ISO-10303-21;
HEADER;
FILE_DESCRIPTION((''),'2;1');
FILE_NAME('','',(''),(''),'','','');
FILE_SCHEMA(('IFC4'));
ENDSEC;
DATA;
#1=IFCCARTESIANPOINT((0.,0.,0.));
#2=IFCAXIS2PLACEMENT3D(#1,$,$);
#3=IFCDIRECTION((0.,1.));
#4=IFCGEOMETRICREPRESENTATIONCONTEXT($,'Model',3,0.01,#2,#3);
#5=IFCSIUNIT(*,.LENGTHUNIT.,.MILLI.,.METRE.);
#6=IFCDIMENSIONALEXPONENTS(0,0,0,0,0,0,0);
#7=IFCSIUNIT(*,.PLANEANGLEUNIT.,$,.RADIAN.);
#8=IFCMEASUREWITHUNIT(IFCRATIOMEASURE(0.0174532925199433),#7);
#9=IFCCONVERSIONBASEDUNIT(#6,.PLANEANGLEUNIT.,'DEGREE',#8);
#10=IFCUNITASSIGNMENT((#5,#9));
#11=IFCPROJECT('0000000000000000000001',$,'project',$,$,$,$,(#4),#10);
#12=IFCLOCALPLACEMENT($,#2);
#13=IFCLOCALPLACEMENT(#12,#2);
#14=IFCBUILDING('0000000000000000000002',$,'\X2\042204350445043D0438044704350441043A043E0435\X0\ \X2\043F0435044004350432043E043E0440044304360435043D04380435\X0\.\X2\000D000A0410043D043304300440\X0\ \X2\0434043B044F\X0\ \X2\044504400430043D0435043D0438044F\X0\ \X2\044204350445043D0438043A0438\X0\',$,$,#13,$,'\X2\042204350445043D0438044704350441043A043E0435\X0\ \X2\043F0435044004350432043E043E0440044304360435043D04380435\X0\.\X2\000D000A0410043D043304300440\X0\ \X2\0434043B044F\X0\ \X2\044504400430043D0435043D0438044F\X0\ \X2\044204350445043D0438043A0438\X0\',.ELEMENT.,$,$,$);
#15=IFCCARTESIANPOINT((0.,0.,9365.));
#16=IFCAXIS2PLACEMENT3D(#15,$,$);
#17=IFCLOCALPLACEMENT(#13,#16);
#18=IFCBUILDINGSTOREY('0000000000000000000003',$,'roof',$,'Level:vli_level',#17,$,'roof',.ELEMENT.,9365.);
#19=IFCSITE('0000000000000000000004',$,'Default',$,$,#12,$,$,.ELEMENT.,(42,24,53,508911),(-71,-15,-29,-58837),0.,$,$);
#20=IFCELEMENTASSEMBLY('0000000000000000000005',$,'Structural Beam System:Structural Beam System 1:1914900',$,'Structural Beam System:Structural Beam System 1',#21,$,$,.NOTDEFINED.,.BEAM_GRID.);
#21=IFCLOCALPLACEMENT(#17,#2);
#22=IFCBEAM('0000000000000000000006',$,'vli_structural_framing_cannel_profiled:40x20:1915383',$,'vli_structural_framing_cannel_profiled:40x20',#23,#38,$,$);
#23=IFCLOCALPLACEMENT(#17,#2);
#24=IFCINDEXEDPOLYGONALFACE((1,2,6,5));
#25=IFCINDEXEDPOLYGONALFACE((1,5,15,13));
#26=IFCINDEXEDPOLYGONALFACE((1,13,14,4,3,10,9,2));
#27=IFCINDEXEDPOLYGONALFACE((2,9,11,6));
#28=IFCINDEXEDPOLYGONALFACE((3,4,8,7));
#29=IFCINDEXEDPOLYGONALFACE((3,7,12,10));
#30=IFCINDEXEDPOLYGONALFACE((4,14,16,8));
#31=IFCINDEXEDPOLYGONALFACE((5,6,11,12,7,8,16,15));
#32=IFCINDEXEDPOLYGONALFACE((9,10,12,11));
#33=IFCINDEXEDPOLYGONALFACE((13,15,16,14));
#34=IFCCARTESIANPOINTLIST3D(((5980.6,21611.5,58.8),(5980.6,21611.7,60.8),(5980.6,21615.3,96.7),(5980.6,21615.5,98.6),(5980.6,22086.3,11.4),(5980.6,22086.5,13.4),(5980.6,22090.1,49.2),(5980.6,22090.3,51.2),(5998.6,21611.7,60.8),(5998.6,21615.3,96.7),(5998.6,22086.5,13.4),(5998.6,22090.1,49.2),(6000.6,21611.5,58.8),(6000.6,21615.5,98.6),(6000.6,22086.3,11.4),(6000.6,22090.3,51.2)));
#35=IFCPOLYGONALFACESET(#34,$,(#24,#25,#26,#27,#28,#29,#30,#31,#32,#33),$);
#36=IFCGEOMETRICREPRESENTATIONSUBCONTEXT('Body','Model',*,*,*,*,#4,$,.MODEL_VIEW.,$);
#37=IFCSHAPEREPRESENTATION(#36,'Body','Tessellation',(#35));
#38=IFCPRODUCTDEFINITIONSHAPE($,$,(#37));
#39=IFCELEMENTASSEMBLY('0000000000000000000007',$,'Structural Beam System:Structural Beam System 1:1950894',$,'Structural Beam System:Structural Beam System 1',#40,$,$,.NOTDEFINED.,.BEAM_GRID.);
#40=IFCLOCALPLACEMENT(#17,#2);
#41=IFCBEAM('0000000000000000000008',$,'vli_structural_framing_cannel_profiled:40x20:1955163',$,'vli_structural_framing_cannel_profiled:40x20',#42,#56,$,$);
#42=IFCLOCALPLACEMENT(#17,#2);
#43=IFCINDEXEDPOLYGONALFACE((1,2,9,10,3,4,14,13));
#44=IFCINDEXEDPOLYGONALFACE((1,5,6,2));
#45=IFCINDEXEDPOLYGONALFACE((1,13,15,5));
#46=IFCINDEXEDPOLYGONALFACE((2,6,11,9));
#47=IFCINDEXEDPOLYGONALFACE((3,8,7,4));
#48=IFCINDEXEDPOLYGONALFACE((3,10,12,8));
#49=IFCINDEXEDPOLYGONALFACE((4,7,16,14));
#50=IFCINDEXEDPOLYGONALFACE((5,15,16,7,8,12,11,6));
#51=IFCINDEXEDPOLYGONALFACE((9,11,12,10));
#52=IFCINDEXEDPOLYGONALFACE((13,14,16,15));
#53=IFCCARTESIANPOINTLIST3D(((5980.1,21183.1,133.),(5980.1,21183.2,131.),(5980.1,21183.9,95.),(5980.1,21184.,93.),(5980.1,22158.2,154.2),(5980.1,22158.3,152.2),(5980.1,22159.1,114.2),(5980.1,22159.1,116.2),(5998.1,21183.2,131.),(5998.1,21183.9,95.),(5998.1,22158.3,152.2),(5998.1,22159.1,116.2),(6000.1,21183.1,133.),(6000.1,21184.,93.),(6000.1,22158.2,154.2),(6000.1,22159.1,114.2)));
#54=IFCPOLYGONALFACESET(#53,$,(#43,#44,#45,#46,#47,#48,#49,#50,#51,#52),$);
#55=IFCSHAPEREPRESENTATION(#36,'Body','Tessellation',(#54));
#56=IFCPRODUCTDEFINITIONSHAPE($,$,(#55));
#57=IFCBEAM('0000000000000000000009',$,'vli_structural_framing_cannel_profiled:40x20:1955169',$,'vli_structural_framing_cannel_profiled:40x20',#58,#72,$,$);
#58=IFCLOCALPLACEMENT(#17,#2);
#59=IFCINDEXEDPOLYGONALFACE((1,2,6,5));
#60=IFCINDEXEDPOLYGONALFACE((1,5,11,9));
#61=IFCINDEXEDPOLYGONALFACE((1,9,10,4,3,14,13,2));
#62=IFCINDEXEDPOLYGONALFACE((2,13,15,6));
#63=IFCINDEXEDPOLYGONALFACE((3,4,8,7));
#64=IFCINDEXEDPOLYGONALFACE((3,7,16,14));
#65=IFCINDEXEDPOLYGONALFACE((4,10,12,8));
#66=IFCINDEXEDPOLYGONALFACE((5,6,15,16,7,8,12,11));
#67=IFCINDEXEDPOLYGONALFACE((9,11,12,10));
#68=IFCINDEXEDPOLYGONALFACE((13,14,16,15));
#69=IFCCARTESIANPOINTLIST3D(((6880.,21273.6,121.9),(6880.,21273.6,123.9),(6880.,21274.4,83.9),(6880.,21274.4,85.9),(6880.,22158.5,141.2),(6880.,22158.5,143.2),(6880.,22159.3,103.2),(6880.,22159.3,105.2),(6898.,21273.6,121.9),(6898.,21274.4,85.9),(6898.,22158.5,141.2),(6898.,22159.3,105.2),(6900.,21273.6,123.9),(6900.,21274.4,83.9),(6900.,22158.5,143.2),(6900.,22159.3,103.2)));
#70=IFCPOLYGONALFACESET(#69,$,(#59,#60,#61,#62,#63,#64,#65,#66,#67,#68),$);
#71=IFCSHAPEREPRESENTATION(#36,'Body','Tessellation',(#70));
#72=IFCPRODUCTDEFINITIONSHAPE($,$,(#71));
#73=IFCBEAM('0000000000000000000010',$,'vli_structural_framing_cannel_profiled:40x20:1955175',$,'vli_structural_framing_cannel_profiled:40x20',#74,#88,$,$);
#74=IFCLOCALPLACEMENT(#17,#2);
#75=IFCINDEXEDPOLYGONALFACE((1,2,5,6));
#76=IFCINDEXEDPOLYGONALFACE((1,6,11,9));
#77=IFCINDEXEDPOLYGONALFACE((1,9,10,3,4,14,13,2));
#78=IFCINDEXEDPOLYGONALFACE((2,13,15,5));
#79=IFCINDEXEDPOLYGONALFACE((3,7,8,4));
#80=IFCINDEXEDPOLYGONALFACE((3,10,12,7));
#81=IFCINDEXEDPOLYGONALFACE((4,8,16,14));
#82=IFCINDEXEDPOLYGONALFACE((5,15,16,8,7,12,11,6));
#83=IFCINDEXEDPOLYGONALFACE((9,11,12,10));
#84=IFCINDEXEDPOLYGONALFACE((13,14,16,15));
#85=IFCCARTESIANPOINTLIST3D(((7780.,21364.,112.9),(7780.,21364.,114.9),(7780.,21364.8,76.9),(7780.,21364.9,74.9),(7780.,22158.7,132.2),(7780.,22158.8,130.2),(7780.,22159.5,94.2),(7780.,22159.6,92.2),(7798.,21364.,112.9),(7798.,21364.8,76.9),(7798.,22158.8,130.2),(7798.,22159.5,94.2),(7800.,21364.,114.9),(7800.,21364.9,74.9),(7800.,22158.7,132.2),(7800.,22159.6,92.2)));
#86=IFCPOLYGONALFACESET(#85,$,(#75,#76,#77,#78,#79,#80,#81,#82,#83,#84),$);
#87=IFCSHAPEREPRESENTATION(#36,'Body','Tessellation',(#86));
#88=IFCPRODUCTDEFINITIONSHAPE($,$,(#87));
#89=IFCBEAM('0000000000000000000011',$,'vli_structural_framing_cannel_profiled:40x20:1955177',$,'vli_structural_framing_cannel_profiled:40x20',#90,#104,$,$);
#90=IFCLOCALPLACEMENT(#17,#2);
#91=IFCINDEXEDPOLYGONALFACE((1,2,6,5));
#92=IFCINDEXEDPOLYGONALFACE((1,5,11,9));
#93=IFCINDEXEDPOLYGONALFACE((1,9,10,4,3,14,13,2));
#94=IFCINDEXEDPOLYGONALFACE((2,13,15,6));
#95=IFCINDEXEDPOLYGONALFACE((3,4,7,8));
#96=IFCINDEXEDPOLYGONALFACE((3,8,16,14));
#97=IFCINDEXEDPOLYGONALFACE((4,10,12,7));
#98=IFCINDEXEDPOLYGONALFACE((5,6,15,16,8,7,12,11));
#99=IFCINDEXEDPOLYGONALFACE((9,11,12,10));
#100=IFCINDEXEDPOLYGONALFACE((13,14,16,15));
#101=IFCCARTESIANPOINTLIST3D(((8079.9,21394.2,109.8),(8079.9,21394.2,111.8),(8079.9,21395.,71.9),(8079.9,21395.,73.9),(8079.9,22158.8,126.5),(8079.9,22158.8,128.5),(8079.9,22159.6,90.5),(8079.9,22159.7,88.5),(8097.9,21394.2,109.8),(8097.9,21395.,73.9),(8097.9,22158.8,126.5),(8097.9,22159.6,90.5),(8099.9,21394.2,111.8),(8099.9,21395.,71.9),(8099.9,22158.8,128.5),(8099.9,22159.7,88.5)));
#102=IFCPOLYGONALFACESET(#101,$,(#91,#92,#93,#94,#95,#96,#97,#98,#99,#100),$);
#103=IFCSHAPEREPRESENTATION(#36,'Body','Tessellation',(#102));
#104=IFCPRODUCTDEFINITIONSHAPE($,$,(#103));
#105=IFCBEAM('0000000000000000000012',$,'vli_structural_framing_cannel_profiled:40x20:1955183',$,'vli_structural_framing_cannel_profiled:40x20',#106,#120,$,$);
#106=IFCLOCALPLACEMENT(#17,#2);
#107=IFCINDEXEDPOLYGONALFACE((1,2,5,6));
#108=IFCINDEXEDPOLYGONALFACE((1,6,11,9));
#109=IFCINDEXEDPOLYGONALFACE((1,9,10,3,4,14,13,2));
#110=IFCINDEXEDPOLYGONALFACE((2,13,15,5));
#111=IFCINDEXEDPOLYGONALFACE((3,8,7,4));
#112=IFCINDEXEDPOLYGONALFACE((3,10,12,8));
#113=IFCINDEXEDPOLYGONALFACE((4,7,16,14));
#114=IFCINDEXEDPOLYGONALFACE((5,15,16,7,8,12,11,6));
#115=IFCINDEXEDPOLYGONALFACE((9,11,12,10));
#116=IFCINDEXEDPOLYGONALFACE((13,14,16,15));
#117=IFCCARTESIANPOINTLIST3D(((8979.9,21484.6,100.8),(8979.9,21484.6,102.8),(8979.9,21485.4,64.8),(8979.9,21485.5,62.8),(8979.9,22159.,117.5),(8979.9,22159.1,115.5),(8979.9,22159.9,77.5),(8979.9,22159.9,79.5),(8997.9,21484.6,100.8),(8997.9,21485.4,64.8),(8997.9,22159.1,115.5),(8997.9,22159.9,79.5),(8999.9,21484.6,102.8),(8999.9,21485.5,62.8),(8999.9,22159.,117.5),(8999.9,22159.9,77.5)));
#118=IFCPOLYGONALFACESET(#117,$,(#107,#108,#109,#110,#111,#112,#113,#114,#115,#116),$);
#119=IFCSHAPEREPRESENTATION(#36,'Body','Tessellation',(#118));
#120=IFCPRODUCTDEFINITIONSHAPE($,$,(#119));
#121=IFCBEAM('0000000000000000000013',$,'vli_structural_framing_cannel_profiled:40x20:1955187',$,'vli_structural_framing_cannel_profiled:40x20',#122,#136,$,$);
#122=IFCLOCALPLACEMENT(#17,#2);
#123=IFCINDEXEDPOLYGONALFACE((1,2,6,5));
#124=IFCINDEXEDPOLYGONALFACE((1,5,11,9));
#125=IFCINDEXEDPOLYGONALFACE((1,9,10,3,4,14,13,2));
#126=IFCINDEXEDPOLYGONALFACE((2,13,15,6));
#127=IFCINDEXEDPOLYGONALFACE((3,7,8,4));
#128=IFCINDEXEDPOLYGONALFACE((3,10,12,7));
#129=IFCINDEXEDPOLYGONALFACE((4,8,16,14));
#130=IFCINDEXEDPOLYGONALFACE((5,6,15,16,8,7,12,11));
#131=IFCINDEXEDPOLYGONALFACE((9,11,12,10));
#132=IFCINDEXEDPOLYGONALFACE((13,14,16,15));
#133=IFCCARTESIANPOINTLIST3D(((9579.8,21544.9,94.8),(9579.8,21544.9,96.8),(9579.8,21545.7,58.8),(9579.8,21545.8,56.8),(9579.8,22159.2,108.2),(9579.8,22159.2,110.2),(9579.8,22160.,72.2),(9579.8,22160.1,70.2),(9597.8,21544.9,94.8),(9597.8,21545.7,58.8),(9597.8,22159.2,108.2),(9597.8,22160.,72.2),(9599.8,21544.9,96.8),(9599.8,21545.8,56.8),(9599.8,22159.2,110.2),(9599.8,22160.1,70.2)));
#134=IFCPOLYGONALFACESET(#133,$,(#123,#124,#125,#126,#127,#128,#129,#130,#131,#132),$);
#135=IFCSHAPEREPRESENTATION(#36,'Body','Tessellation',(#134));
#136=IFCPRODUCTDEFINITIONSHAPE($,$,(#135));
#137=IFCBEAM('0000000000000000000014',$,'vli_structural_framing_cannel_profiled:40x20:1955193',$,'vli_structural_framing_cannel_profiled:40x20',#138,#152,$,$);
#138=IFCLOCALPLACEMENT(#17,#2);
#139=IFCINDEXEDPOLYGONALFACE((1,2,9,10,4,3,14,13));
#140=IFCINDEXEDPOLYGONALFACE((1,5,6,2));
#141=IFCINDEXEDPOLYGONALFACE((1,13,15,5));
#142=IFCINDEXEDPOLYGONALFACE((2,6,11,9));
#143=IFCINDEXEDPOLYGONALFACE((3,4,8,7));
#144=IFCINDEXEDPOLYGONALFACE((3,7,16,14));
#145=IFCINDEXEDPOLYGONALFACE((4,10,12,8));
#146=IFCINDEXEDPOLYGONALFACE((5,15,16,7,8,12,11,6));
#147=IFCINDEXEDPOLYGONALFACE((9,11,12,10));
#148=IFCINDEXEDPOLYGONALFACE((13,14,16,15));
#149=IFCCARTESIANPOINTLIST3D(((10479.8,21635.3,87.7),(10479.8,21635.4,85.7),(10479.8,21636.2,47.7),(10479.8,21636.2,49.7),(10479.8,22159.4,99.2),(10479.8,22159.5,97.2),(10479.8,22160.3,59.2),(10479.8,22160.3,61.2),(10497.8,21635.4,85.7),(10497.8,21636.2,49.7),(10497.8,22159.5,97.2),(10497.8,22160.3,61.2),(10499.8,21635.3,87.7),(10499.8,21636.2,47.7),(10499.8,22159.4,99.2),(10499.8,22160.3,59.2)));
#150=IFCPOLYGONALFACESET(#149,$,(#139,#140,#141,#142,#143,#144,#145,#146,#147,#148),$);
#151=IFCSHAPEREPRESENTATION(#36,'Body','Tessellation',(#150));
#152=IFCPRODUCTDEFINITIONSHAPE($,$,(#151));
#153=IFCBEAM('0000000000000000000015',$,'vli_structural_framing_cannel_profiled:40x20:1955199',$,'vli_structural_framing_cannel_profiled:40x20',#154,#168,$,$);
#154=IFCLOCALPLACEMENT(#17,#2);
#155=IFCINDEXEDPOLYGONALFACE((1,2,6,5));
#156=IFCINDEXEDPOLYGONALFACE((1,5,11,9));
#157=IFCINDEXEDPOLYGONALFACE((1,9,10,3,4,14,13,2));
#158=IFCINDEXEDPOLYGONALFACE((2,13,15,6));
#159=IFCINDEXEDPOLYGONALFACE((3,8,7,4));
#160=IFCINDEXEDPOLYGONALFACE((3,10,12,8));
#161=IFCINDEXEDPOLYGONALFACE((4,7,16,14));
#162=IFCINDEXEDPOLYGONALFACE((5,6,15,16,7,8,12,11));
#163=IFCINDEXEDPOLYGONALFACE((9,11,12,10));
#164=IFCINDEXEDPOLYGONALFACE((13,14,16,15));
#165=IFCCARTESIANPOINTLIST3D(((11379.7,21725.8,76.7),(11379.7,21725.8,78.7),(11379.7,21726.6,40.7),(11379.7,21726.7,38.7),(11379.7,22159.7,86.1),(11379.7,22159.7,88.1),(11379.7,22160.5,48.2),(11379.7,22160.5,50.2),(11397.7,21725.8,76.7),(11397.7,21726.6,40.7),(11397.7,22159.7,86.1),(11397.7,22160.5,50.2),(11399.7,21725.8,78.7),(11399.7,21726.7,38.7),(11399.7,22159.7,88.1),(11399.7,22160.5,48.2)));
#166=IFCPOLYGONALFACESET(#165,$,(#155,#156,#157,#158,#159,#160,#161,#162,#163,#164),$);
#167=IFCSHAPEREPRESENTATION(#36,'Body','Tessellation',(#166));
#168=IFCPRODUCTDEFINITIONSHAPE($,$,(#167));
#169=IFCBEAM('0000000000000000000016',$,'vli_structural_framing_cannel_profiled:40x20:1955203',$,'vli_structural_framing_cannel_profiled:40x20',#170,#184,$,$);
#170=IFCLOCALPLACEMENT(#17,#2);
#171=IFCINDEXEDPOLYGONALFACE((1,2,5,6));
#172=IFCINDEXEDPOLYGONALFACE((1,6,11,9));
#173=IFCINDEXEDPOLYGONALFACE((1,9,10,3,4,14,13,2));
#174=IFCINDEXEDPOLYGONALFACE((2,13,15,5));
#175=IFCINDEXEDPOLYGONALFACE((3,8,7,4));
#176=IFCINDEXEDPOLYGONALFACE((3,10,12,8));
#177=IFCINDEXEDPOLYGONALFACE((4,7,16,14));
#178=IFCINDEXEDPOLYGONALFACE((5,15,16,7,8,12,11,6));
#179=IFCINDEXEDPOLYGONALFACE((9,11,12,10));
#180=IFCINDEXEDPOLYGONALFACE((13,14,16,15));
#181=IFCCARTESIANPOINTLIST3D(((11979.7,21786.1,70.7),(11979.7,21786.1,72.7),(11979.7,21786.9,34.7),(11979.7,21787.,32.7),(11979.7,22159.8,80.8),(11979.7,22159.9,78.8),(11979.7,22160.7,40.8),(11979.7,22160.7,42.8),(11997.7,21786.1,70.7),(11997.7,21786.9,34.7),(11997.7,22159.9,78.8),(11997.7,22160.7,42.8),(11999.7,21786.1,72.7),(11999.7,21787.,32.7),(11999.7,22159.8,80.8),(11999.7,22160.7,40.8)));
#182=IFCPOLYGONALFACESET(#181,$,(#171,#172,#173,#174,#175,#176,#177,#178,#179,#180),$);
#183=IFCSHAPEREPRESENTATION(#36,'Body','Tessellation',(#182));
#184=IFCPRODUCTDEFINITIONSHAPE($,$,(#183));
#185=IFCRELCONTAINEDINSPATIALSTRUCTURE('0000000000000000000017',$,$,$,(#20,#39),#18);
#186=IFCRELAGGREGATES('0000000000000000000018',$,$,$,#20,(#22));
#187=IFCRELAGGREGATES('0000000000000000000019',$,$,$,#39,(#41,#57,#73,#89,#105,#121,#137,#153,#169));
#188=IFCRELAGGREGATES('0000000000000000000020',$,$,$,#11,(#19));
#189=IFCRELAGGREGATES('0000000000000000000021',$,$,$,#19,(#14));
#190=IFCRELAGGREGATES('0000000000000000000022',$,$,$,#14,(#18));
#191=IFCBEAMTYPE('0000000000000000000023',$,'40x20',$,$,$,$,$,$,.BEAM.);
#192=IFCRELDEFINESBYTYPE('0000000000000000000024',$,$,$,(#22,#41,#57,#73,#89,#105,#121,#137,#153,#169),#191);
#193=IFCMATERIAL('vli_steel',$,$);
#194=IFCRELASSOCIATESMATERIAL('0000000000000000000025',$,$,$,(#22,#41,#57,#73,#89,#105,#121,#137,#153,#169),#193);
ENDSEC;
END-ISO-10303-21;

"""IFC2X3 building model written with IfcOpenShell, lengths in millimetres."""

from ifc_helpers import new_model, entity, si_unit, converted_unit, direction, frame, origin, place, context, subcontext, project, spatial, polyline, outline, extrude, material, type_object, element, aggregate, save


model = new_model("IFC2X3")

# Units and contexts
model_context = context("Model", 3, precision=0.01, world=origin(), true_north=direction((0.0, 1.0)))
body_context = subcontext(model_context, "Body", "Model", "MODEL_VIEW")
ifc_project = project(units=[si_unit("LENGTHUNIT", "METRE", prefix="MILLI"), converted_unit("PLANEANGLEUNIT", "DEGREE", entity("IfcRatioMeasure", 0.0174532925199433), si_unit("PLANEANGLEUNIT", "RADIAN"), dimensions=[0, 0, 0, 0, 0, 0, 0])], contexts=[model_context])

# Site, building, storey
site_placement = place(None, origin())
site = spatial("IfcSite", under=ifc_project, at=site_placement, Name="Default", CompositionType="ELEMENT", RefLatitude=(42, 24, 53, 508911), RefLongitude=(-71, -15, -29, -58837), RefElevation=0.0)
building_placement = place(site_placement, origin())
building = spatial("IfcBuilding", under=site, at=building_placement, Name="Техническое перевооружение.\r\nАнгар для хранения техники", LongName="Техническое перевооружение.\r\nАнгар для хранения техники", CompositionType="ELEMENT")
storey_placement = place(building_placement, frame((0.0, 0.0, 9365.0)))
storey = spatial("IfcBuildingStorey", under=building, at=storey_placement, Name="roof", ObjectType="Level:vli_level", LongName="roof", CompositionType="ELEMENT", Elevation=9365.0)

# Element assemblies, beams
assembly_1_placement = place(storey_placement, origin())
assembly_1 = element("IfcElementAssembly", 1, at=assembly_1_placement, inside=storey, Name="Structural Beam System:Structural Beam System 1:1914900", ObjectType="Structural Beam System:Structural Beam System 1", AssemblyPlace="NOTDEFINED", PredefinedType="BEAM_GRID")
ifc_material = material(Name="vli_steel")
beam_type = type_object("IfcBeamType", Name="40x20", PredefinedType="BEAM")
beam_1_placement = place(assembly_1_placement, frame((6000.0, 22090.8, 10.9), z_axis=(0.0, 0.099504, 0.995037), x_axis=(0.0, -0.995037, 0.099504)))
beam_1 = element("IfcBeam", 2, at=beam_1_placement, type_object=beam_type, material=ifc_material, Name="vli_structural_framing_cannel_profiled:40x20:1915383", ObjectType="vli_structural_framing_cannel_profiled:40x20", context=body_context, shape_type="SweptSolid", body=[
    extrude(outline(polyline([(-20.0, -9.5), (-18.0, -9.5), (-18.0, 8.5), (18.0, 8.5), (18.0, -9.5), (20.0, -9.5), (20.0, 10.5), (-20.0, 10.5), (-20.0, -9.5)])), frame((4.6, -9.9, 20.0), z_axis=(1.0, 0.0, 0.0), x_axis=(0.0, 0.0, -1.0)), (0.0, 0.0, 1.0), 477.1),
])
aggregate(assembly_1, [beam_1])
assembly_2_placement = place(storey_placement, origin())
assembly_2 = element("IfcElementAssembly", 3, at=assembly_2_placement, inside=storey, Name="Structural Beam System:Structural Beam System 1:1950894", ObjectType="Structural Beam System:Structural Beam System 1", AssemblyPlace="NOTDEFINED", PredefinedType="BEAM_GRID")
beam_2_placement = place(assembly_2_placement, frame((5999.5, 22159.7, 154.2), z_axis=(0.0, -0.021793, 0.999763), x_axis=(0.0, -0.999763, -0.021793)))
beam_2 = element("IfcBeam", 4, at=beam_2_placement, type_object=beam_type, material=ifc_material, Name="vli_structural_framing_cannel_profiled:40x20:1955163", ObjectType="vli_structural_framing_cannel_profiled:40x20", context=body_context, shape_type="SweptSolid", body=[
    extrude(outline(polyline([(-20.0, -9.5), (-18.0, -9.5), (-18.0, 8.5), (18.0, 8.5), (18.0, -9.5), (20.0, -9.5), (20.0, 10.5), (-20.0, 10.5), (-20.0, -9.5)])), frame((1.5, -9.9, -20.0), z_axis=(1.0, 0.0, 0.0), x_axis=(0.0, 0.0, -1.0)), (0.0, 0.0, 1.0), 975.4),
])
beam_3_placement = place(assembly_2_placement, frame((6899.4, 22159.9, 143.2), z_axis=(0.0, -0.021793, 0.999763), x_axis=(0.0, -0.999763, -0.021793)))
beam_3 = element("IfcBeam", 5, at=beam_3_placement, type_object=beam_type, material=ifc_material, Name="vli_structural_framing_cannel_profiled:40x20:1955169", ObjectType="vli_structural_framing_cannel_profiled:40x20", context=body_context, shape_type="SweptSolid", body=[
    extrude(outline(polyline([(-20.0, -9.5), (-18.0, -9.5), (-18.0, 8.5), (18.0, 8.5), (18.0, -9.5), (20.0, -9.5), (20.0, 10.5), (-20.0, 10.5), (-20.0, -9.5)])), frame((1.5, -9.9, -20.0), z_axis=(1.0, 0.0, 0.0), x_axis=(0.0, 0.0, -1.0)), (0.0, 0.0, 1.0), 885.1),
])
beam_4_placement = place(assembly_2_placement, frame((7799.4, 22160.2, 132.2), z_axis=(0.0, -0.021793, 0.999763), x_axis=(0.0, -0.999763, -0.021793)))
beam_4 = element("IfcBeam", 6, at=beam_4_placement, type_object=beam_type, material=ifc_material, Name="vli_structural_framing_cannel_profiled:40x20:1955175", ObjectType="vli_structural_framing_cannel_profiled:40x20", context=body_context, shape_type="SweptSolid", body=[
    extrude(outline(polyline([(-20.0, -9.5), (-18.0, -9.5), (-18.0, 8.5), (18.0, 8.5), (18.0, -9.5), (20.0, -9.5), (20.0, 10.5), (-20.0, 10.5), (-20.0, -9.5)])), frame((1.5, -9.9, -20.0), z_axis=(1.0, 0.0, 0.0), x_axis=(0.0, 0.0, -1.0)), (0.0, 0.0, 1.0), 794.9),
])
beam_5_placement = place(assembly_2_placement, frame((8099.3, 22160.3, 128.5), z_axis=(0.0, -0.021793, 0.999763), x_axis=(0.0, -0.999763, -0.021793)))
beam_5 = element("IfcBeam", 7, at=beam_5_placement, type_object=beam_type, material=ifc_material, Name="vli_structural_framing_cannel_profiled:40x20:1955177", ObjectType="vli_structural_framing_cannel_profiled:40x20", context=body_context, shape_type="SweptSolid", body=[
    extrude(outline(polyline([(-20.0, -9.5), (-18.0, -9.5), (-18.0, 8.5), (18.0, 8.5), (18.0, -9.5), (20.0, -9.5), (20.0, 10.5), (-20.0, 10.5), (-20.0, -9.5)])), frame((1.5, -9.9, -20.0), z_axis=(1.0, 0.0, 0.0), x_axis=(0.0, 0.0, -1.0)), (0.0, 0.0, 1.0), 764.8),
])
beam_6_placement = place(assembly_2_placement, frame((8999.3, 22160.5, 117.5), z_axis=(0.0, -0.021793, 0.999763), x_axis=(0.0, -0.999763, -0.021793)))
beam_6 = element("IfcBeam", 8, at=beam_6_placement, type_object=beam_type, material=ifc_material, Name="vli_structural_framing_cannel_profiled:40x20:1955183", ObjectType="vli_structural_framing_cannel_profiled:40x20", context=body_context, shape_type="SweptSolid", body=[
    extrude(outline(polyline([(-20.0, -9.5), (-18.0, -9.5), (-18.0, 8.5), (18.0, 8.5), (18.0, -9.5), (20.0, -9.5), (20.0, 10.5), (-20.0, 10.5), (-20.0, -9.5)])), frame((1.5, -9.9, -20.0), z_axis=(1.0, 0.0, 0.0), x_axis=(0.0, 0.0, -1.0)), (0.0, 0.0, 1.0), 674.6),
])
beam_7_placement = place(assembly_2_placement, frame((9599.2, 22160.7, 110.2), z_axis=(0.0, -0.021793, 0.999763), x_axis=(0.0, -0.999763, -0.021793)))
beam_7 = element("IfcBeam", 9, at=beam_7_placement, type_object=beam_type, material=ifc_material, Name="vli_structural_framing_cannel_profiled:40x20:1955187", ObjectType="vli_structural_framing_cannel_profiled:40x20", context=body_context, shape_type="SweptSolid", body=[
    extrude(outline(polyline([(-20.0, -9.5), (-18.0, -9.5), (-18.0, 8.5), (18.0, 8.5), (18.0, -9.5), (20.0, -9.5), (20.0, 10.5), (-20.0, 10.5), (-20.0, -9.5)])), frame((1.5, -9.9, -20.0), z_axis=(1.0, 0.0, 0.0), x_axis=(0.0, 0.0, -1.0)), (0.0, 0.0, 1.0), 614.4),
])
beam_8_placement = place(assembly_2_placement, frame((10499.2, 22160.9, 99.2), z_axis=(0.0, -0.021793, 0.999763), x_axis=(0.0, -0.999763, -0.021793)))
beam_8 = element("IfcBeam", 10, at=beam_8_placement, type_object=beam_type, material=ifc_material, Name="vli_structural_framing_cannel_profiled:40x20:1955193", ObjectType="vli_structural_framing_cannel_profiled:40x20", context=body_context, shape_type="SweptSolid", body=[
    extrude(outline(polyline([(-20.0, -9.5), (-18.0, -9.5), (-18.0, 8.5), (18.0, 8.5), (18.0, -9.5), (20.0, -9.5), (20.0, 10.5), (-20.0, 10.5), (-20.0, -9.5)])), frame((1.5, -9.9, -20.0), z_axis=(1.0, 0.0, 0.0), x_axis=(0.0, 0.0, -1.0)), (0.0, 0.0, 1.0), 524.2),
])
beam_9_placement = place(assembly_2_placement, frame((11399.1, 22161.1, 88.2), z_axis=(0.0, -0.021793, 0.999763), x_axis=(0.0, -0.999763, -0.021793)))
beam_9 = element("IfcBeam", 11, at=beam_9_placement, type_object=beam_type, material=ifc_material, Name="vli_structural_framing_cannel_profiled:40x20:1955199", ObjectType="vli_structural_framing_cannel_profiled:40x20", context=body_context, shape_type="SweptSolid", body=[
    extrude(outline(polyline([(-20.0, -9.5), (-18.0, -9.5), (-18.0, 8.5), (18.0, 8.5), (18.0, -9.5), (20.0, -9.5), (20.0, 10.5), (-20.0, 10.5), (-20.0, -9.5)])), frame((1.5, -9.9, -20.0), z_axis=(1.0, 0.0, 0.0), x_axis=(0.0, 0.0, -1.0)), (0.0, 0.0, 1.0), 434.0),
])
beam_10_placement = place(assembly_2_placement, frame((11999.1, 22161.3, 80.8), z_axis=(0.0, -0.021793, 0.999763), x_axis=(0.0, -0.999763, -0.021793)))
beam_10 = element("IfcBeam", 12, at=beam_10_placement, type_object=beam_type, material=ifc_material, Name="vli_structural_framing_cannel_profiled:40x20:1955203", ObjectType="vli_structural_framing_cannel_profiled:40x20", context=body_context, shape_type="SweptSolid", body=[
    extrude(outline(polyline([(-20.0, -9.5), (-18.0, -9.5), (-18.0, 8.5), (18.0, 8.5), (18.0, -9.5), (20.0, -9.5), (20.0, 10.5), (-20.0, 10.5), (-20.0, -9.5)])), frame((1.5, -9.9, -20.0), z_axis=(1.0, 0.0, 0.0), x_axis=(0.0, 0.0, -1.0)), (0.0, 0.0, 1.0), 373.8),
])

aggregate(assembly_2, [beam_2, beam_3, beam_4, beam_5, beam_6, beam_7, beam_8, beam_9, beam_10])

save(model, "model.ifc")
